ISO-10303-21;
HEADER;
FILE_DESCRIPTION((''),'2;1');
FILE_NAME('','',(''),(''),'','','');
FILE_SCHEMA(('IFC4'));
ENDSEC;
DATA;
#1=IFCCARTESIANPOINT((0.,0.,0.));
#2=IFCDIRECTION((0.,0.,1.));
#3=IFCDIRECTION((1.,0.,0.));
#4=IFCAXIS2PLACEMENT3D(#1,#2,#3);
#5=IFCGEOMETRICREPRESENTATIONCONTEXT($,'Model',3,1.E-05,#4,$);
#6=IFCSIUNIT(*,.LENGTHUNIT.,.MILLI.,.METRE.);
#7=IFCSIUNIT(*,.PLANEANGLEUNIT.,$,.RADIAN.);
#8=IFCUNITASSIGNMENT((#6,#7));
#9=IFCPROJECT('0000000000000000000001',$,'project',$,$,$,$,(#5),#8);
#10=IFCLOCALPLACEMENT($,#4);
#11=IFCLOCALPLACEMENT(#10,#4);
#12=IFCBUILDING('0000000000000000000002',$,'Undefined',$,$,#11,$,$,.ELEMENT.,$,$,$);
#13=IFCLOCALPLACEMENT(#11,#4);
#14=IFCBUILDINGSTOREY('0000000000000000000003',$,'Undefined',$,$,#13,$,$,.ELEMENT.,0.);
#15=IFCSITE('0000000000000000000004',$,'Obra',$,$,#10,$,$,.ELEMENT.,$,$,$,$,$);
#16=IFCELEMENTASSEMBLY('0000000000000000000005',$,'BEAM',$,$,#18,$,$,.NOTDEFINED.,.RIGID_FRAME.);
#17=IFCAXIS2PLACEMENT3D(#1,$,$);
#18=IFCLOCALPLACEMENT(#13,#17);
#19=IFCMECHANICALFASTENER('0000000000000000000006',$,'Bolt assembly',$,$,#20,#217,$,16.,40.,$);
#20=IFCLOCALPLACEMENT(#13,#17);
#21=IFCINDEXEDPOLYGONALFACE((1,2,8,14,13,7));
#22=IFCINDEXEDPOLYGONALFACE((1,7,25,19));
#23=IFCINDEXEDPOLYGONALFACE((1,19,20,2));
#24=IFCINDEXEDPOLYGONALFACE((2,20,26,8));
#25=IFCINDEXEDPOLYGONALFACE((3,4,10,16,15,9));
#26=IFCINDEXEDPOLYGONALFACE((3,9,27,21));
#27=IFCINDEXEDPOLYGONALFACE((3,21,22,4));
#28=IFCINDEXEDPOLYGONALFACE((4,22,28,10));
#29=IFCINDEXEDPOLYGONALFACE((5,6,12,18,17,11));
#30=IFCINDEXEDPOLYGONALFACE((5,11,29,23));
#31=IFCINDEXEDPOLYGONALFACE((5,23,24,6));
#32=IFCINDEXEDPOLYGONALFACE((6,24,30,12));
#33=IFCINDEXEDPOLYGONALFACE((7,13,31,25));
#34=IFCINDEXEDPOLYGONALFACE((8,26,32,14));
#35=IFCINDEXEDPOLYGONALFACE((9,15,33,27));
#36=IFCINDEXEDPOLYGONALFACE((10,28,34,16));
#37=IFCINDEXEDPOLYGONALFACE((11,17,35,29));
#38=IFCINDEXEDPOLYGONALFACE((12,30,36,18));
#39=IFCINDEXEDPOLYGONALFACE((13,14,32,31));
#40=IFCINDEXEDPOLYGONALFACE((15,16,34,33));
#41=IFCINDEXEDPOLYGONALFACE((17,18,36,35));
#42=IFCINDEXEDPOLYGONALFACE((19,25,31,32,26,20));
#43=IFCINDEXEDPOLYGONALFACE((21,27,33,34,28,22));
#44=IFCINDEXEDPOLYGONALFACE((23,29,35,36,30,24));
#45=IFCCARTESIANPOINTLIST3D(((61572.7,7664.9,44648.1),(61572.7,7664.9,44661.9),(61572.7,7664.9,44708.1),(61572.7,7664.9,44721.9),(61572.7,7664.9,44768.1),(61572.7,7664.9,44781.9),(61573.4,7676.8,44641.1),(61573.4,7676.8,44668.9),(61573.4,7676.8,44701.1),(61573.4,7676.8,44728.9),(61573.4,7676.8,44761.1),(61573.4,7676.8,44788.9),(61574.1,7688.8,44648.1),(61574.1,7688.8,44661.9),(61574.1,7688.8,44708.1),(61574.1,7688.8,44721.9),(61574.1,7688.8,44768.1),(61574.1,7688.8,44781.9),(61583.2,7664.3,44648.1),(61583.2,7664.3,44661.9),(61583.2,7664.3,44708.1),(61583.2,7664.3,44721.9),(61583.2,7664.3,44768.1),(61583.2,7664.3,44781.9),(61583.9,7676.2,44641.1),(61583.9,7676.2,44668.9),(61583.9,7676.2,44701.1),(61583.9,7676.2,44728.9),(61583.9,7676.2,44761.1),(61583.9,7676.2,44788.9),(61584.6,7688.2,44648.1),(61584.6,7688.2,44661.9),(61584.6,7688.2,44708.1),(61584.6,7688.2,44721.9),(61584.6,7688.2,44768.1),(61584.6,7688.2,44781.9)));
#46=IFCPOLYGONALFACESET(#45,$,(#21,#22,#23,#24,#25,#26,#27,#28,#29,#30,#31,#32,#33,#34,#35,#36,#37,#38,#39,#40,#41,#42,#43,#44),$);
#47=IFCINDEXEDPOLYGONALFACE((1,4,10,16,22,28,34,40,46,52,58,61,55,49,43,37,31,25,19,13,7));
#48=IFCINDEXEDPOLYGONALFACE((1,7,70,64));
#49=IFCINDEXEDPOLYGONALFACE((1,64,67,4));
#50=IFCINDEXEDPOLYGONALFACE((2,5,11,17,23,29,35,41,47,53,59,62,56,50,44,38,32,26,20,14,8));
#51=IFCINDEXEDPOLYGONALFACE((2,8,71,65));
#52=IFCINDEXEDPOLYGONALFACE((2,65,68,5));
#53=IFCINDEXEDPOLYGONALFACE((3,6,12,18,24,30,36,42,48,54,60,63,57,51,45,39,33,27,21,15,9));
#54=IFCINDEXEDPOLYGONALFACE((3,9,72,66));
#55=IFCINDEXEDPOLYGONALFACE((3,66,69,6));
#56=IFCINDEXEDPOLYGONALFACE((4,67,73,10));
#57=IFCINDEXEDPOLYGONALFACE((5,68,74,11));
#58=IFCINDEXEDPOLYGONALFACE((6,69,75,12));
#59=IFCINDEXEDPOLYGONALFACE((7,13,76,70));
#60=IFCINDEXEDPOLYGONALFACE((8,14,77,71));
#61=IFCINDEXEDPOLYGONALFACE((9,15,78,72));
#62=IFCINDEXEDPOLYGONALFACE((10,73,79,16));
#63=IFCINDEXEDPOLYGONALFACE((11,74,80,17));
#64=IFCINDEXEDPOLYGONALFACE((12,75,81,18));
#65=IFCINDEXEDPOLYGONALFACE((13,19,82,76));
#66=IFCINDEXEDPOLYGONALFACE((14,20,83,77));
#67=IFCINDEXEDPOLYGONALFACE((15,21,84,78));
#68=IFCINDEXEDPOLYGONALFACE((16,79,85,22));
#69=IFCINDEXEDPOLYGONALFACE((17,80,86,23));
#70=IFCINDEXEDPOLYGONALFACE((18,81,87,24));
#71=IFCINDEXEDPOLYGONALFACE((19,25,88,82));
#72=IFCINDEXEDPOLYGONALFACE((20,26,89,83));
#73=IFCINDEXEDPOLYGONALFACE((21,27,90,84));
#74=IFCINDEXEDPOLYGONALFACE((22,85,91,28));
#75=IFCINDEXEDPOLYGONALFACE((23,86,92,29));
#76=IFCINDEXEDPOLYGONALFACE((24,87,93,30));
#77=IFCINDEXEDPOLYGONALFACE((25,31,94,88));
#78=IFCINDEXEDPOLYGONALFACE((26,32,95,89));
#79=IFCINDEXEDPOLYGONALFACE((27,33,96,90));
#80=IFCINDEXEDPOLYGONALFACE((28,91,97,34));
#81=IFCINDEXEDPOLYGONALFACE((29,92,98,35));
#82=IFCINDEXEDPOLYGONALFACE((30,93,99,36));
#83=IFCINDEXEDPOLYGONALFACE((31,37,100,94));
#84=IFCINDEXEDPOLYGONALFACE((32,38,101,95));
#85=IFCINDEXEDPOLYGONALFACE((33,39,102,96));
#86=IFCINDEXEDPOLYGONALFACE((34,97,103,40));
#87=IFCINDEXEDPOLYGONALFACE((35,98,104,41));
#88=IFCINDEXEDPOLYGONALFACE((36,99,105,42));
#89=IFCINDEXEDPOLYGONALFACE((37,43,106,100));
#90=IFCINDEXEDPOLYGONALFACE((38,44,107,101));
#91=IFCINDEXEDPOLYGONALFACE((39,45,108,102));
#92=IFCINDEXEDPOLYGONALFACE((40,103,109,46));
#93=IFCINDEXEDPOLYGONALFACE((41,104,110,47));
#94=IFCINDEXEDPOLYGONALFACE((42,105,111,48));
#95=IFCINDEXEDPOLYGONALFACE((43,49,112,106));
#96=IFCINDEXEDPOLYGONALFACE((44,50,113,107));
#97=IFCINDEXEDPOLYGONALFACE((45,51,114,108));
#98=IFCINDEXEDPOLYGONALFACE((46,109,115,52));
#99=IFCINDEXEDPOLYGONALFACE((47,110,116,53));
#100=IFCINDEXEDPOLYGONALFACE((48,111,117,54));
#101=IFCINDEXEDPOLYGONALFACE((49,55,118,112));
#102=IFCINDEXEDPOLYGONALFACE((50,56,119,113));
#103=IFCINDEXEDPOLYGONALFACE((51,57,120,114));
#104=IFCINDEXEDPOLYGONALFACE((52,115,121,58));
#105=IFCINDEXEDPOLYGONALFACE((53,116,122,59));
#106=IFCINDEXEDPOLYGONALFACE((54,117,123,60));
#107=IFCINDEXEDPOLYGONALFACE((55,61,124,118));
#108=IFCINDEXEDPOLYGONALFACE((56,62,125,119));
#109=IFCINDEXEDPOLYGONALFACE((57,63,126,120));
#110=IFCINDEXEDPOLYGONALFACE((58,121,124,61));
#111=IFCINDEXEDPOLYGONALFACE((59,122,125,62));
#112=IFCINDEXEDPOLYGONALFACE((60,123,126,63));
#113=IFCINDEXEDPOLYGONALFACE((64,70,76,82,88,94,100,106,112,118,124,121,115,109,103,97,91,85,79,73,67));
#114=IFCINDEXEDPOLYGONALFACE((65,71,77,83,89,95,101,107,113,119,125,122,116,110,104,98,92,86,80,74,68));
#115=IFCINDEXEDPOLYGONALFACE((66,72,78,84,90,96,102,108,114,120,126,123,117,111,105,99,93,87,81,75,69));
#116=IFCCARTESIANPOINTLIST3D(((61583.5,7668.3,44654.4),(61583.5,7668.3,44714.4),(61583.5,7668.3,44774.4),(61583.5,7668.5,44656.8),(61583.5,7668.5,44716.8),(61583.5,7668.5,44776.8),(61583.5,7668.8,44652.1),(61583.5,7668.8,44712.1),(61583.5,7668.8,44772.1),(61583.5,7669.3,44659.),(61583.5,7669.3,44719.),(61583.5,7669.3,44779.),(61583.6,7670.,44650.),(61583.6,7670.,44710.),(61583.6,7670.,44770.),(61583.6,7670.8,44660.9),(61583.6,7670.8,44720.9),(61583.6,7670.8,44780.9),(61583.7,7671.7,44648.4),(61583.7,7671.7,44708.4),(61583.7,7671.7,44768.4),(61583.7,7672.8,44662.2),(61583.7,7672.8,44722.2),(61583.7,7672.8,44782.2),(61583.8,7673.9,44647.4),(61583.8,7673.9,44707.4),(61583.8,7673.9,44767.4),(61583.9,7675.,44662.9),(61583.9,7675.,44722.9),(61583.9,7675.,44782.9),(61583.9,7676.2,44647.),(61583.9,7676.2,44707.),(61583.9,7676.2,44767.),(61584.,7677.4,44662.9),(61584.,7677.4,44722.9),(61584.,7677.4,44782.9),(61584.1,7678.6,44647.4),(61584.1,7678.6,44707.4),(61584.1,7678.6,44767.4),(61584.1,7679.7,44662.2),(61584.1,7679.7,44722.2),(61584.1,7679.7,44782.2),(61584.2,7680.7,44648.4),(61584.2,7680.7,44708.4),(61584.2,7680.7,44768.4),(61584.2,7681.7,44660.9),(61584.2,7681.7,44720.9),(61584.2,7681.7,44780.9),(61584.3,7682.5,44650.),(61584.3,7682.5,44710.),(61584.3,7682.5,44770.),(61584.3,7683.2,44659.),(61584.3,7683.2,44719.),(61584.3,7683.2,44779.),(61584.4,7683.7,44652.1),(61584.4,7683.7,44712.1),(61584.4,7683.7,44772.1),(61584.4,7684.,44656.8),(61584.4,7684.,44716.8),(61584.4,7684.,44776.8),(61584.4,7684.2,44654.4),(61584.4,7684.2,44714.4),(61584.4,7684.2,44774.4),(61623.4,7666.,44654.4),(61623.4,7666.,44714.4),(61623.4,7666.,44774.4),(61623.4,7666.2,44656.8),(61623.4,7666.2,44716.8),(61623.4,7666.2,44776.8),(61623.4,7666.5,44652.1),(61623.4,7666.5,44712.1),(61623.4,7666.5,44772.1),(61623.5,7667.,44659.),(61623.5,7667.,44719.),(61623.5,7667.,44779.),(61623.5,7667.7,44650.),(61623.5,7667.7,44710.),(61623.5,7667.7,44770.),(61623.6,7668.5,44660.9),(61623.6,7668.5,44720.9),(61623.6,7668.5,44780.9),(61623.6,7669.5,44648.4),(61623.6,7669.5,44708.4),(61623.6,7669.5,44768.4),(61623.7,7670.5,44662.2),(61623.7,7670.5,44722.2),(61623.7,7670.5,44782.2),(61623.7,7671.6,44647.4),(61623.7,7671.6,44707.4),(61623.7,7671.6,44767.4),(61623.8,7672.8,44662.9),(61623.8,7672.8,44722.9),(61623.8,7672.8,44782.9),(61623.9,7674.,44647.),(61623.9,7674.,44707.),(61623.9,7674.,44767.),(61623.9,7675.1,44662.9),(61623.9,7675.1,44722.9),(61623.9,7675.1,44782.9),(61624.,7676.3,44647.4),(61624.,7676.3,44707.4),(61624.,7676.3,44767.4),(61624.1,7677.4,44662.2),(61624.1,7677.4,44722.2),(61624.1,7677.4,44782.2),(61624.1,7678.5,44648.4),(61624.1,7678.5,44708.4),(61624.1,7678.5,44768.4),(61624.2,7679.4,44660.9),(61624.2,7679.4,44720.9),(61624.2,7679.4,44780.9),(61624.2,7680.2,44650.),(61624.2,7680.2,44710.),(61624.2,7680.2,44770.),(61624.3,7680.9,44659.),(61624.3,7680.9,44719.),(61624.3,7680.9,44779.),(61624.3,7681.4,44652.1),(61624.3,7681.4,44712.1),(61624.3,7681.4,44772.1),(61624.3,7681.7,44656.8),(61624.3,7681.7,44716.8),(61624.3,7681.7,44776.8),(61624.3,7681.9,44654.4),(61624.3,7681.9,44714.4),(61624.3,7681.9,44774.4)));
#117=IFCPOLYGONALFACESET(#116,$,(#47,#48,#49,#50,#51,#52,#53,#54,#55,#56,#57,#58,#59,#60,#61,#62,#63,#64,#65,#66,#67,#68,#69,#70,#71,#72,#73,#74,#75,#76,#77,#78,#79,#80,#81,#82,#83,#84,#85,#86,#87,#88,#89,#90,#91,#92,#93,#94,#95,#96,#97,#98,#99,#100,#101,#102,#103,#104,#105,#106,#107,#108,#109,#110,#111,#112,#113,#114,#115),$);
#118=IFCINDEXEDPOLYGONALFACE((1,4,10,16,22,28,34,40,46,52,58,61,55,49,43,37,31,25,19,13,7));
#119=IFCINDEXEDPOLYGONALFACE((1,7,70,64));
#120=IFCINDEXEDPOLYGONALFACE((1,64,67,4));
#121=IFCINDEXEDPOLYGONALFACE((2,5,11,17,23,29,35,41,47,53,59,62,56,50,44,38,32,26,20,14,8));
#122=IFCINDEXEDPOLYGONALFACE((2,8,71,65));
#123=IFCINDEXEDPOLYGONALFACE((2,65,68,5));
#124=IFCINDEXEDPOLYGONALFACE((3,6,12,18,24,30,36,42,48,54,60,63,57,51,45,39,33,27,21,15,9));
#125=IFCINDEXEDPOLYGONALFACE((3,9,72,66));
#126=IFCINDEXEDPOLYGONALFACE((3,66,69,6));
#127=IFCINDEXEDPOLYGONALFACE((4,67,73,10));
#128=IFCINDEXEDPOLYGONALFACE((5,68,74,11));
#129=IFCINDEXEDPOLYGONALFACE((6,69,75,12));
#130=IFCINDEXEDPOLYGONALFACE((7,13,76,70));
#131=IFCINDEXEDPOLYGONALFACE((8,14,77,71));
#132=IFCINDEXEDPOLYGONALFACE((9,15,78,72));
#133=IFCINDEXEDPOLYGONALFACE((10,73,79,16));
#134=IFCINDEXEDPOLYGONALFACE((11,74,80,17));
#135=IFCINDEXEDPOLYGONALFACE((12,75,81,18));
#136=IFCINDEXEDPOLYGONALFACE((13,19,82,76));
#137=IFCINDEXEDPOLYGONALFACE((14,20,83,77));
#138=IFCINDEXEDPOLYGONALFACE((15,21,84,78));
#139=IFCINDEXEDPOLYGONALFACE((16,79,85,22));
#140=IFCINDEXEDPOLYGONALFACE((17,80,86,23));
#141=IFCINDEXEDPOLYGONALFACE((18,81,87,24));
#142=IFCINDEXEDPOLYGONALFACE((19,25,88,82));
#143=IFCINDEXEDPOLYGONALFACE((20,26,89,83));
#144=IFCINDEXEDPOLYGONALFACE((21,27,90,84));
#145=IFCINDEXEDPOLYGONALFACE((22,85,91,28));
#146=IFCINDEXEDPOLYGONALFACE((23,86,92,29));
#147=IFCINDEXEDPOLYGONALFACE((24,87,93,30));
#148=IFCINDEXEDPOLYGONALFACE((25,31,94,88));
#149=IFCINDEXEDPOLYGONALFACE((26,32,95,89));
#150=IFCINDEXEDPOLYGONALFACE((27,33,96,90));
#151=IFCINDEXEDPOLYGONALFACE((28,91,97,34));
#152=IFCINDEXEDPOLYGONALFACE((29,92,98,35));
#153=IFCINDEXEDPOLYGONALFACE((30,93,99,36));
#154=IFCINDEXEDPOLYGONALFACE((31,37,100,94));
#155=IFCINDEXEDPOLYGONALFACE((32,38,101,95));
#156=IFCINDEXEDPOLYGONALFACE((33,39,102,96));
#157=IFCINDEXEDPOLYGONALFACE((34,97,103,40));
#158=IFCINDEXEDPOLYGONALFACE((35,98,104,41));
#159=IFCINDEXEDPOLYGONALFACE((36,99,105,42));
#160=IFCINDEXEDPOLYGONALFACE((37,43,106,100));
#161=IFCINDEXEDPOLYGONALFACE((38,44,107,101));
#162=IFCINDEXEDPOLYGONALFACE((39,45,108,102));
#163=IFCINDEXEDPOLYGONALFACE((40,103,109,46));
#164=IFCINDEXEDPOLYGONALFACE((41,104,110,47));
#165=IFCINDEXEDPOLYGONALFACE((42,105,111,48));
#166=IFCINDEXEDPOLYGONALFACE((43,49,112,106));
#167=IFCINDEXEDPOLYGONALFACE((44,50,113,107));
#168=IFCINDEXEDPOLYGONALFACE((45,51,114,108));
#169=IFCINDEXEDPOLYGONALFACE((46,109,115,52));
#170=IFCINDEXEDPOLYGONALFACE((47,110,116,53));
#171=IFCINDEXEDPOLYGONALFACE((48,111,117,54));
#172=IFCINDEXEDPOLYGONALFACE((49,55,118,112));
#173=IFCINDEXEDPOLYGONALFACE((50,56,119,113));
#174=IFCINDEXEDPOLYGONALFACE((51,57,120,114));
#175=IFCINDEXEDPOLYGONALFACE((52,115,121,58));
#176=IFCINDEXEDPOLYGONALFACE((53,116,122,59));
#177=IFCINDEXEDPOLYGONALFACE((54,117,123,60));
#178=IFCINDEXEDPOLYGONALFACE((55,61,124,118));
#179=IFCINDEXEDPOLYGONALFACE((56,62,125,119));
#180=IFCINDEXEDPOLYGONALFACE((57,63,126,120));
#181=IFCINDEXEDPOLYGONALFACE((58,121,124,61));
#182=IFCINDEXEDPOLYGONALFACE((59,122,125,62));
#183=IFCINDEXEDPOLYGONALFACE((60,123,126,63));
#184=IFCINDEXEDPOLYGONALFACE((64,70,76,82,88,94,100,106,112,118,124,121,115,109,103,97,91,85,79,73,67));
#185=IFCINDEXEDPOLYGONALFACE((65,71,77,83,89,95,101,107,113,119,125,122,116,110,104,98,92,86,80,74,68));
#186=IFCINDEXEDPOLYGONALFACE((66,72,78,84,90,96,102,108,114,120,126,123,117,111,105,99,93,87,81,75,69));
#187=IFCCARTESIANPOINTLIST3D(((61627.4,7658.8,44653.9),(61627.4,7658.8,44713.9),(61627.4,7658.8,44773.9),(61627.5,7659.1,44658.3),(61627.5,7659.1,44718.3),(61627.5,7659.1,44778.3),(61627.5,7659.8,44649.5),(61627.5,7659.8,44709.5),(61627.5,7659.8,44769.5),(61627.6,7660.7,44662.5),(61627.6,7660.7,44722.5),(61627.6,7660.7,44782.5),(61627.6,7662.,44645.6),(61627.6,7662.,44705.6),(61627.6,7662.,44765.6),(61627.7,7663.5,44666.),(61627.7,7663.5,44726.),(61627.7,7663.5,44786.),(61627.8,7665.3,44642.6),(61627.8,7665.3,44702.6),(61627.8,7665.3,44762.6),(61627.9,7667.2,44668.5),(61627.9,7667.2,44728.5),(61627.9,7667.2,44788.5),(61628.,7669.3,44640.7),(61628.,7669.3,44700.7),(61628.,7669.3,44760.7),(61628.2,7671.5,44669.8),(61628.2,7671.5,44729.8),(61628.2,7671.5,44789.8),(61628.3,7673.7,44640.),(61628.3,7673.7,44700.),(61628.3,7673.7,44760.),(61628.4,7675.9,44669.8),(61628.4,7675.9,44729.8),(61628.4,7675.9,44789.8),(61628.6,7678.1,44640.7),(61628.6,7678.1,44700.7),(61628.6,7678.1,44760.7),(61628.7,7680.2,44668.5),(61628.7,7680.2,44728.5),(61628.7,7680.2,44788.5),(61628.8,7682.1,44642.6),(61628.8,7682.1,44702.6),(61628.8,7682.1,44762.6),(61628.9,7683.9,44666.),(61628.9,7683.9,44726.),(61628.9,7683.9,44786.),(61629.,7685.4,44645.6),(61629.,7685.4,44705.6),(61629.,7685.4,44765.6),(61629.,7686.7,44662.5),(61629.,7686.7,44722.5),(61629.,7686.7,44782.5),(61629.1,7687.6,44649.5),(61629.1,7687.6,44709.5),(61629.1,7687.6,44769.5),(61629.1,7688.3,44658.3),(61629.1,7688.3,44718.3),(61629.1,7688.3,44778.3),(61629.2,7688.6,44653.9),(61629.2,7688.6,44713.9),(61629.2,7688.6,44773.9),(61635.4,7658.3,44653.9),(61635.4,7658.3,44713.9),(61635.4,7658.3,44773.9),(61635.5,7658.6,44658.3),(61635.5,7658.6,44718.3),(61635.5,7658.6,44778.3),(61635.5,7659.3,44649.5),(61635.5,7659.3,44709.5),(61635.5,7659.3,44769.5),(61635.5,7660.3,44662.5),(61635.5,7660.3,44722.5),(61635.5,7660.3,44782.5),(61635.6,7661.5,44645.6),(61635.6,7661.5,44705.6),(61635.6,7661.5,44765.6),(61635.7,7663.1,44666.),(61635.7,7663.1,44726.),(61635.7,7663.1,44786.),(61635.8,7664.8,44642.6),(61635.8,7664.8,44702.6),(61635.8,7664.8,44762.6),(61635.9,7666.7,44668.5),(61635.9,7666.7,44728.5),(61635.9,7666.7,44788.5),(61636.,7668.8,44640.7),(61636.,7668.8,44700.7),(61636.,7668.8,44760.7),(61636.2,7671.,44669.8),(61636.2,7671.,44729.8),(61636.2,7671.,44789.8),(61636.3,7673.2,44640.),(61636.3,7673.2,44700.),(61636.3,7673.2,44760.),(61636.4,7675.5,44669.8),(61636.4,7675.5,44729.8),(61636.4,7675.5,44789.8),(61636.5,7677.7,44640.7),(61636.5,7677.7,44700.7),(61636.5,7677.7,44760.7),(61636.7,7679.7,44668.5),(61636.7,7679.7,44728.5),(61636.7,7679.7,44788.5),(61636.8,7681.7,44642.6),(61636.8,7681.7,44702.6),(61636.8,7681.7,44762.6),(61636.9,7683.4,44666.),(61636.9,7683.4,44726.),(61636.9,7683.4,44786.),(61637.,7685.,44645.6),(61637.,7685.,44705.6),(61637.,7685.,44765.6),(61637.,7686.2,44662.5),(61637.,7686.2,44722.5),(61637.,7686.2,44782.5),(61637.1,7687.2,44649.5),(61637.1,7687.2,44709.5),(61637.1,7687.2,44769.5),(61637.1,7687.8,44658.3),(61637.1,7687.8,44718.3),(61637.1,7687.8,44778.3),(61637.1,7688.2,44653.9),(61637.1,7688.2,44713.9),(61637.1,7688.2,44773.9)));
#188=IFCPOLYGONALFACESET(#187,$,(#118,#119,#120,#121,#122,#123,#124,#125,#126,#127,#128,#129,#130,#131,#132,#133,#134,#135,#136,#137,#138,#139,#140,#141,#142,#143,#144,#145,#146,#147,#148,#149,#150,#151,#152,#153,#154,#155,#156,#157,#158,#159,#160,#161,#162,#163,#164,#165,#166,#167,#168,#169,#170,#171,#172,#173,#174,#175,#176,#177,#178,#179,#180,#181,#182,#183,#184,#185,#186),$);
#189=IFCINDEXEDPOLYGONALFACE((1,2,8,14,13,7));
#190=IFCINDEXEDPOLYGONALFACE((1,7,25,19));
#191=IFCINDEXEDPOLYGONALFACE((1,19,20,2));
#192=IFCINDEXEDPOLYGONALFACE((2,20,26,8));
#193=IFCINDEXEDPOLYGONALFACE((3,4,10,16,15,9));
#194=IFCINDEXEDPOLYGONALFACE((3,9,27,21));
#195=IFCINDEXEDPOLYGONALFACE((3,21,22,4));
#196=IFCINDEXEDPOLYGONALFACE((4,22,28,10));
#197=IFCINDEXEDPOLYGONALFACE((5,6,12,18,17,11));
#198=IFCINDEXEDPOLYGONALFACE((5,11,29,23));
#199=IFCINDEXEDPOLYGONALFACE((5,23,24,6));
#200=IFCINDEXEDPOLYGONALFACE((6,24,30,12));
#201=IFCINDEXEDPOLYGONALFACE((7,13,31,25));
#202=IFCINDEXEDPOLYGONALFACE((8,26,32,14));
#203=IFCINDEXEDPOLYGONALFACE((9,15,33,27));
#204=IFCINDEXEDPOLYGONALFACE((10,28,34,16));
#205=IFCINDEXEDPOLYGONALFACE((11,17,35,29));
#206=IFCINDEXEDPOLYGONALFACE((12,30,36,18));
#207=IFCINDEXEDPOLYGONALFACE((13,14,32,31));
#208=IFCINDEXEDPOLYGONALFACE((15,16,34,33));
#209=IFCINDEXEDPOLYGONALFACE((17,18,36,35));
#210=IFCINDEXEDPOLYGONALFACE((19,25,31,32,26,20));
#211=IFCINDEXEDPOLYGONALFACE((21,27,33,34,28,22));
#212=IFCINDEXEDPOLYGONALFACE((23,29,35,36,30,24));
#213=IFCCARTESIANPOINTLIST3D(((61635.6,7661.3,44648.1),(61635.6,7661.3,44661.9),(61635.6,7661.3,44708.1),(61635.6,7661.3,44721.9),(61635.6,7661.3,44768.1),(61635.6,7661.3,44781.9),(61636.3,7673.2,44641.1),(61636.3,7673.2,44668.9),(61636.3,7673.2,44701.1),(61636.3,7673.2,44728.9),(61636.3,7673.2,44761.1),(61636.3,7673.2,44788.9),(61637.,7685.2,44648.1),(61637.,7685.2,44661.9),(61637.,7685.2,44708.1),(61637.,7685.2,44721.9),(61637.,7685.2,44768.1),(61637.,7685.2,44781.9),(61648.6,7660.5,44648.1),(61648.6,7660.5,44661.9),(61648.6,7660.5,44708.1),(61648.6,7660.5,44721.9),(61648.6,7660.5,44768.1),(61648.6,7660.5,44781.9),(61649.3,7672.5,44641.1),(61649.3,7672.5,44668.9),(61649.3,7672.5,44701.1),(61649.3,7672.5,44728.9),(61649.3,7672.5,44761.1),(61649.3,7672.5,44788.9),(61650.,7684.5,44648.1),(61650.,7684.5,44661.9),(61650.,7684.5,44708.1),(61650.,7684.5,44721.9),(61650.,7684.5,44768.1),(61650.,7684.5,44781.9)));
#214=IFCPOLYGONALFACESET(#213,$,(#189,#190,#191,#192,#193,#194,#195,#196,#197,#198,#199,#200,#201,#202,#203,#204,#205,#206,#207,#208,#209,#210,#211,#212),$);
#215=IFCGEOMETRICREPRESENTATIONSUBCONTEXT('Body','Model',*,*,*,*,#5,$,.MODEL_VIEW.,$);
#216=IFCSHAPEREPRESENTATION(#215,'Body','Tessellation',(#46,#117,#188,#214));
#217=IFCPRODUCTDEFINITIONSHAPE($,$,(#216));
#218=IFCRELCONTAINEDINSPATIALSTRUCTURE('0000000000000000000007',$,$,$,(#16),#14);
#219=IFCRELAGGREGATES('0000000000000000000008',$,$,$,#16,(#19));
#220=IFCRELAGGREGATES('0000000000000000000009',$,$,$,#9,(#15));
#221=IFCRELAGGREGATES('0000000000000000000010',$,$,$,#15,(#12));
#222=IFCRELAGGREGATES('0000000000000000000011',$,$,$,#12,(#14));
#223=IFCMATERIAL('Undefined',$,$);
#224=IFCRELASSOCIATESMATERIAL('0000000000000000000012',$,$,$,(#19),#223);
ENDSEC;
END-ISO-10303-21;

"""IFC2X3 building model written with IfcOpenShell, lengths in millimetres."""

from ifc_helpers import new_model, si_unit, frame, origin_with_axes, origin_2d_with_axis, place, context, subcontext, project, spatial, polyline, circle, outline, extrude, source, transform, mapped, material, element, aggregate, save


model = new_model("IFC2X3")

# Units and contexts
model_context = context("Model", 3, precision=1e-05, world=origin_with_axes())
body_context = subcontext(model_context, "Body", "Model", "MODEL_VIEW")
ifc_project = project(units=[si_unit("LENGTHUNIT", "METRE", prefix="MILLI"), si_unit("PLANEANGLEUNIT", "RADIAN")], contexts=[model_context])

# Site, building, storey
site_placement = place(None, origin_with_axes())
site = spatial("IfcSite", under=ifc_project, at=site_placement, Name="Obra", CompositionType="ELEMENT")
building_placement = place(site_placement, origin_with_axes())
building = spatial("IfcBuilding", under=site, at=building_placement, Name="Undefined", CompositionType="ELEMENT")
storey_placement = place(building_placement, origin_with_axes())
storey = spatial("IfcBuildingStorey", under=building, at=storey_placement, Name="Undefined", CompositionType="ELEMENT", Elevation=0.0)

# Element assembly
assembly_1_placement = place(storey_placement, origin_with_axes())
assembly_1 = element("IfcElementAssembly", 1, at=assembly_1_placement, inside=storey, Name="BEAM", AssemblyPlace="NOTDEFINED", PredefinedType="RIGID_FRAME")

# Shared definitions
ifc_material_1 = material(Name="Undefined")
shared_shape_1 = source(origin_with_axes(), body_context, "Body", "SweptSolid", [
    extrude(outline(polyline([(13.9, 0.0), (6.9, 12.0), (-6.9, 12.0), (-13.9, 0.0), (-6.9, -12.0), (6.9, -12.0), (13.9, 0.0)])), frame((0.0, -19.7, 0.0), z_axis=(0.0, 1.0, 0.0), x_axis=(1.0, 0.0, 0.0)), (0.0, 0.0, 1.0), 10.6),
    extrude(circle(Radius=8.0, at=origin_2d_with_axis()), frame((0.0, -9.1, 0.0), z_axis=(0.0, 1.0, 0.0), x_axis=(1.0, 0.0, 0.0)), (0.0, 0.0, 1.0), 40.0),
    extrude(circle(Radius=15.0, at=origin_2d_with_axis()), frame((0.0, 35.3, 0.0), z_axis=(0.0, 1.0, 0.0), x_axis=(1.0, 0.0, 0.0)), (0.0, 0.0, 1.0), 8.0),
    extrude(outline(polyline([(13.9, 0.0), (6.9, 12.0), (-6.9, 12.0), (-13.9, 0.0), (-6.9, -12.0), (6.9, -12.0), (13.9, 0.0)])), frame((0.0, 43.3, 0.0), z_axis=(0.0, 1.0, 0.0), x_axis=(1.0, 0.0, 0.0)), (0.0, 0.0, 1.0), 13.0),
])

# Mechanical fastener
mechanical_fastener_1_placement = place(assembly_1_placement, frame((61595.9, 7725.6, 44835.0), z_axis=(-0.05711, -0.998368, 0.0), x_axis=(0.0, 0.0, -1.0)))
mechanical_fastener_1 = element("IfcMechanicalFastener", 2, at=mechanical_fastener_1_placement, material=ifc_material_1, Name="Bolt assembly", NominalDiameter=16.0, NominalLength=40.0, context=body_context, shape_type="MappedRepresentation", body=[
    mapped(shared_shape_1, transform((60.0, 0.0, 50.0))),
    mapped(shared_shape_1, transform((120.0, 0.0, 50.0))),
    mapped(shared_shape_1, transform((180.0, 0.0, 50.0))),
])
aggregate(assembly_1, [mechanical_fastener_1])

save(model, "model.ifc")
